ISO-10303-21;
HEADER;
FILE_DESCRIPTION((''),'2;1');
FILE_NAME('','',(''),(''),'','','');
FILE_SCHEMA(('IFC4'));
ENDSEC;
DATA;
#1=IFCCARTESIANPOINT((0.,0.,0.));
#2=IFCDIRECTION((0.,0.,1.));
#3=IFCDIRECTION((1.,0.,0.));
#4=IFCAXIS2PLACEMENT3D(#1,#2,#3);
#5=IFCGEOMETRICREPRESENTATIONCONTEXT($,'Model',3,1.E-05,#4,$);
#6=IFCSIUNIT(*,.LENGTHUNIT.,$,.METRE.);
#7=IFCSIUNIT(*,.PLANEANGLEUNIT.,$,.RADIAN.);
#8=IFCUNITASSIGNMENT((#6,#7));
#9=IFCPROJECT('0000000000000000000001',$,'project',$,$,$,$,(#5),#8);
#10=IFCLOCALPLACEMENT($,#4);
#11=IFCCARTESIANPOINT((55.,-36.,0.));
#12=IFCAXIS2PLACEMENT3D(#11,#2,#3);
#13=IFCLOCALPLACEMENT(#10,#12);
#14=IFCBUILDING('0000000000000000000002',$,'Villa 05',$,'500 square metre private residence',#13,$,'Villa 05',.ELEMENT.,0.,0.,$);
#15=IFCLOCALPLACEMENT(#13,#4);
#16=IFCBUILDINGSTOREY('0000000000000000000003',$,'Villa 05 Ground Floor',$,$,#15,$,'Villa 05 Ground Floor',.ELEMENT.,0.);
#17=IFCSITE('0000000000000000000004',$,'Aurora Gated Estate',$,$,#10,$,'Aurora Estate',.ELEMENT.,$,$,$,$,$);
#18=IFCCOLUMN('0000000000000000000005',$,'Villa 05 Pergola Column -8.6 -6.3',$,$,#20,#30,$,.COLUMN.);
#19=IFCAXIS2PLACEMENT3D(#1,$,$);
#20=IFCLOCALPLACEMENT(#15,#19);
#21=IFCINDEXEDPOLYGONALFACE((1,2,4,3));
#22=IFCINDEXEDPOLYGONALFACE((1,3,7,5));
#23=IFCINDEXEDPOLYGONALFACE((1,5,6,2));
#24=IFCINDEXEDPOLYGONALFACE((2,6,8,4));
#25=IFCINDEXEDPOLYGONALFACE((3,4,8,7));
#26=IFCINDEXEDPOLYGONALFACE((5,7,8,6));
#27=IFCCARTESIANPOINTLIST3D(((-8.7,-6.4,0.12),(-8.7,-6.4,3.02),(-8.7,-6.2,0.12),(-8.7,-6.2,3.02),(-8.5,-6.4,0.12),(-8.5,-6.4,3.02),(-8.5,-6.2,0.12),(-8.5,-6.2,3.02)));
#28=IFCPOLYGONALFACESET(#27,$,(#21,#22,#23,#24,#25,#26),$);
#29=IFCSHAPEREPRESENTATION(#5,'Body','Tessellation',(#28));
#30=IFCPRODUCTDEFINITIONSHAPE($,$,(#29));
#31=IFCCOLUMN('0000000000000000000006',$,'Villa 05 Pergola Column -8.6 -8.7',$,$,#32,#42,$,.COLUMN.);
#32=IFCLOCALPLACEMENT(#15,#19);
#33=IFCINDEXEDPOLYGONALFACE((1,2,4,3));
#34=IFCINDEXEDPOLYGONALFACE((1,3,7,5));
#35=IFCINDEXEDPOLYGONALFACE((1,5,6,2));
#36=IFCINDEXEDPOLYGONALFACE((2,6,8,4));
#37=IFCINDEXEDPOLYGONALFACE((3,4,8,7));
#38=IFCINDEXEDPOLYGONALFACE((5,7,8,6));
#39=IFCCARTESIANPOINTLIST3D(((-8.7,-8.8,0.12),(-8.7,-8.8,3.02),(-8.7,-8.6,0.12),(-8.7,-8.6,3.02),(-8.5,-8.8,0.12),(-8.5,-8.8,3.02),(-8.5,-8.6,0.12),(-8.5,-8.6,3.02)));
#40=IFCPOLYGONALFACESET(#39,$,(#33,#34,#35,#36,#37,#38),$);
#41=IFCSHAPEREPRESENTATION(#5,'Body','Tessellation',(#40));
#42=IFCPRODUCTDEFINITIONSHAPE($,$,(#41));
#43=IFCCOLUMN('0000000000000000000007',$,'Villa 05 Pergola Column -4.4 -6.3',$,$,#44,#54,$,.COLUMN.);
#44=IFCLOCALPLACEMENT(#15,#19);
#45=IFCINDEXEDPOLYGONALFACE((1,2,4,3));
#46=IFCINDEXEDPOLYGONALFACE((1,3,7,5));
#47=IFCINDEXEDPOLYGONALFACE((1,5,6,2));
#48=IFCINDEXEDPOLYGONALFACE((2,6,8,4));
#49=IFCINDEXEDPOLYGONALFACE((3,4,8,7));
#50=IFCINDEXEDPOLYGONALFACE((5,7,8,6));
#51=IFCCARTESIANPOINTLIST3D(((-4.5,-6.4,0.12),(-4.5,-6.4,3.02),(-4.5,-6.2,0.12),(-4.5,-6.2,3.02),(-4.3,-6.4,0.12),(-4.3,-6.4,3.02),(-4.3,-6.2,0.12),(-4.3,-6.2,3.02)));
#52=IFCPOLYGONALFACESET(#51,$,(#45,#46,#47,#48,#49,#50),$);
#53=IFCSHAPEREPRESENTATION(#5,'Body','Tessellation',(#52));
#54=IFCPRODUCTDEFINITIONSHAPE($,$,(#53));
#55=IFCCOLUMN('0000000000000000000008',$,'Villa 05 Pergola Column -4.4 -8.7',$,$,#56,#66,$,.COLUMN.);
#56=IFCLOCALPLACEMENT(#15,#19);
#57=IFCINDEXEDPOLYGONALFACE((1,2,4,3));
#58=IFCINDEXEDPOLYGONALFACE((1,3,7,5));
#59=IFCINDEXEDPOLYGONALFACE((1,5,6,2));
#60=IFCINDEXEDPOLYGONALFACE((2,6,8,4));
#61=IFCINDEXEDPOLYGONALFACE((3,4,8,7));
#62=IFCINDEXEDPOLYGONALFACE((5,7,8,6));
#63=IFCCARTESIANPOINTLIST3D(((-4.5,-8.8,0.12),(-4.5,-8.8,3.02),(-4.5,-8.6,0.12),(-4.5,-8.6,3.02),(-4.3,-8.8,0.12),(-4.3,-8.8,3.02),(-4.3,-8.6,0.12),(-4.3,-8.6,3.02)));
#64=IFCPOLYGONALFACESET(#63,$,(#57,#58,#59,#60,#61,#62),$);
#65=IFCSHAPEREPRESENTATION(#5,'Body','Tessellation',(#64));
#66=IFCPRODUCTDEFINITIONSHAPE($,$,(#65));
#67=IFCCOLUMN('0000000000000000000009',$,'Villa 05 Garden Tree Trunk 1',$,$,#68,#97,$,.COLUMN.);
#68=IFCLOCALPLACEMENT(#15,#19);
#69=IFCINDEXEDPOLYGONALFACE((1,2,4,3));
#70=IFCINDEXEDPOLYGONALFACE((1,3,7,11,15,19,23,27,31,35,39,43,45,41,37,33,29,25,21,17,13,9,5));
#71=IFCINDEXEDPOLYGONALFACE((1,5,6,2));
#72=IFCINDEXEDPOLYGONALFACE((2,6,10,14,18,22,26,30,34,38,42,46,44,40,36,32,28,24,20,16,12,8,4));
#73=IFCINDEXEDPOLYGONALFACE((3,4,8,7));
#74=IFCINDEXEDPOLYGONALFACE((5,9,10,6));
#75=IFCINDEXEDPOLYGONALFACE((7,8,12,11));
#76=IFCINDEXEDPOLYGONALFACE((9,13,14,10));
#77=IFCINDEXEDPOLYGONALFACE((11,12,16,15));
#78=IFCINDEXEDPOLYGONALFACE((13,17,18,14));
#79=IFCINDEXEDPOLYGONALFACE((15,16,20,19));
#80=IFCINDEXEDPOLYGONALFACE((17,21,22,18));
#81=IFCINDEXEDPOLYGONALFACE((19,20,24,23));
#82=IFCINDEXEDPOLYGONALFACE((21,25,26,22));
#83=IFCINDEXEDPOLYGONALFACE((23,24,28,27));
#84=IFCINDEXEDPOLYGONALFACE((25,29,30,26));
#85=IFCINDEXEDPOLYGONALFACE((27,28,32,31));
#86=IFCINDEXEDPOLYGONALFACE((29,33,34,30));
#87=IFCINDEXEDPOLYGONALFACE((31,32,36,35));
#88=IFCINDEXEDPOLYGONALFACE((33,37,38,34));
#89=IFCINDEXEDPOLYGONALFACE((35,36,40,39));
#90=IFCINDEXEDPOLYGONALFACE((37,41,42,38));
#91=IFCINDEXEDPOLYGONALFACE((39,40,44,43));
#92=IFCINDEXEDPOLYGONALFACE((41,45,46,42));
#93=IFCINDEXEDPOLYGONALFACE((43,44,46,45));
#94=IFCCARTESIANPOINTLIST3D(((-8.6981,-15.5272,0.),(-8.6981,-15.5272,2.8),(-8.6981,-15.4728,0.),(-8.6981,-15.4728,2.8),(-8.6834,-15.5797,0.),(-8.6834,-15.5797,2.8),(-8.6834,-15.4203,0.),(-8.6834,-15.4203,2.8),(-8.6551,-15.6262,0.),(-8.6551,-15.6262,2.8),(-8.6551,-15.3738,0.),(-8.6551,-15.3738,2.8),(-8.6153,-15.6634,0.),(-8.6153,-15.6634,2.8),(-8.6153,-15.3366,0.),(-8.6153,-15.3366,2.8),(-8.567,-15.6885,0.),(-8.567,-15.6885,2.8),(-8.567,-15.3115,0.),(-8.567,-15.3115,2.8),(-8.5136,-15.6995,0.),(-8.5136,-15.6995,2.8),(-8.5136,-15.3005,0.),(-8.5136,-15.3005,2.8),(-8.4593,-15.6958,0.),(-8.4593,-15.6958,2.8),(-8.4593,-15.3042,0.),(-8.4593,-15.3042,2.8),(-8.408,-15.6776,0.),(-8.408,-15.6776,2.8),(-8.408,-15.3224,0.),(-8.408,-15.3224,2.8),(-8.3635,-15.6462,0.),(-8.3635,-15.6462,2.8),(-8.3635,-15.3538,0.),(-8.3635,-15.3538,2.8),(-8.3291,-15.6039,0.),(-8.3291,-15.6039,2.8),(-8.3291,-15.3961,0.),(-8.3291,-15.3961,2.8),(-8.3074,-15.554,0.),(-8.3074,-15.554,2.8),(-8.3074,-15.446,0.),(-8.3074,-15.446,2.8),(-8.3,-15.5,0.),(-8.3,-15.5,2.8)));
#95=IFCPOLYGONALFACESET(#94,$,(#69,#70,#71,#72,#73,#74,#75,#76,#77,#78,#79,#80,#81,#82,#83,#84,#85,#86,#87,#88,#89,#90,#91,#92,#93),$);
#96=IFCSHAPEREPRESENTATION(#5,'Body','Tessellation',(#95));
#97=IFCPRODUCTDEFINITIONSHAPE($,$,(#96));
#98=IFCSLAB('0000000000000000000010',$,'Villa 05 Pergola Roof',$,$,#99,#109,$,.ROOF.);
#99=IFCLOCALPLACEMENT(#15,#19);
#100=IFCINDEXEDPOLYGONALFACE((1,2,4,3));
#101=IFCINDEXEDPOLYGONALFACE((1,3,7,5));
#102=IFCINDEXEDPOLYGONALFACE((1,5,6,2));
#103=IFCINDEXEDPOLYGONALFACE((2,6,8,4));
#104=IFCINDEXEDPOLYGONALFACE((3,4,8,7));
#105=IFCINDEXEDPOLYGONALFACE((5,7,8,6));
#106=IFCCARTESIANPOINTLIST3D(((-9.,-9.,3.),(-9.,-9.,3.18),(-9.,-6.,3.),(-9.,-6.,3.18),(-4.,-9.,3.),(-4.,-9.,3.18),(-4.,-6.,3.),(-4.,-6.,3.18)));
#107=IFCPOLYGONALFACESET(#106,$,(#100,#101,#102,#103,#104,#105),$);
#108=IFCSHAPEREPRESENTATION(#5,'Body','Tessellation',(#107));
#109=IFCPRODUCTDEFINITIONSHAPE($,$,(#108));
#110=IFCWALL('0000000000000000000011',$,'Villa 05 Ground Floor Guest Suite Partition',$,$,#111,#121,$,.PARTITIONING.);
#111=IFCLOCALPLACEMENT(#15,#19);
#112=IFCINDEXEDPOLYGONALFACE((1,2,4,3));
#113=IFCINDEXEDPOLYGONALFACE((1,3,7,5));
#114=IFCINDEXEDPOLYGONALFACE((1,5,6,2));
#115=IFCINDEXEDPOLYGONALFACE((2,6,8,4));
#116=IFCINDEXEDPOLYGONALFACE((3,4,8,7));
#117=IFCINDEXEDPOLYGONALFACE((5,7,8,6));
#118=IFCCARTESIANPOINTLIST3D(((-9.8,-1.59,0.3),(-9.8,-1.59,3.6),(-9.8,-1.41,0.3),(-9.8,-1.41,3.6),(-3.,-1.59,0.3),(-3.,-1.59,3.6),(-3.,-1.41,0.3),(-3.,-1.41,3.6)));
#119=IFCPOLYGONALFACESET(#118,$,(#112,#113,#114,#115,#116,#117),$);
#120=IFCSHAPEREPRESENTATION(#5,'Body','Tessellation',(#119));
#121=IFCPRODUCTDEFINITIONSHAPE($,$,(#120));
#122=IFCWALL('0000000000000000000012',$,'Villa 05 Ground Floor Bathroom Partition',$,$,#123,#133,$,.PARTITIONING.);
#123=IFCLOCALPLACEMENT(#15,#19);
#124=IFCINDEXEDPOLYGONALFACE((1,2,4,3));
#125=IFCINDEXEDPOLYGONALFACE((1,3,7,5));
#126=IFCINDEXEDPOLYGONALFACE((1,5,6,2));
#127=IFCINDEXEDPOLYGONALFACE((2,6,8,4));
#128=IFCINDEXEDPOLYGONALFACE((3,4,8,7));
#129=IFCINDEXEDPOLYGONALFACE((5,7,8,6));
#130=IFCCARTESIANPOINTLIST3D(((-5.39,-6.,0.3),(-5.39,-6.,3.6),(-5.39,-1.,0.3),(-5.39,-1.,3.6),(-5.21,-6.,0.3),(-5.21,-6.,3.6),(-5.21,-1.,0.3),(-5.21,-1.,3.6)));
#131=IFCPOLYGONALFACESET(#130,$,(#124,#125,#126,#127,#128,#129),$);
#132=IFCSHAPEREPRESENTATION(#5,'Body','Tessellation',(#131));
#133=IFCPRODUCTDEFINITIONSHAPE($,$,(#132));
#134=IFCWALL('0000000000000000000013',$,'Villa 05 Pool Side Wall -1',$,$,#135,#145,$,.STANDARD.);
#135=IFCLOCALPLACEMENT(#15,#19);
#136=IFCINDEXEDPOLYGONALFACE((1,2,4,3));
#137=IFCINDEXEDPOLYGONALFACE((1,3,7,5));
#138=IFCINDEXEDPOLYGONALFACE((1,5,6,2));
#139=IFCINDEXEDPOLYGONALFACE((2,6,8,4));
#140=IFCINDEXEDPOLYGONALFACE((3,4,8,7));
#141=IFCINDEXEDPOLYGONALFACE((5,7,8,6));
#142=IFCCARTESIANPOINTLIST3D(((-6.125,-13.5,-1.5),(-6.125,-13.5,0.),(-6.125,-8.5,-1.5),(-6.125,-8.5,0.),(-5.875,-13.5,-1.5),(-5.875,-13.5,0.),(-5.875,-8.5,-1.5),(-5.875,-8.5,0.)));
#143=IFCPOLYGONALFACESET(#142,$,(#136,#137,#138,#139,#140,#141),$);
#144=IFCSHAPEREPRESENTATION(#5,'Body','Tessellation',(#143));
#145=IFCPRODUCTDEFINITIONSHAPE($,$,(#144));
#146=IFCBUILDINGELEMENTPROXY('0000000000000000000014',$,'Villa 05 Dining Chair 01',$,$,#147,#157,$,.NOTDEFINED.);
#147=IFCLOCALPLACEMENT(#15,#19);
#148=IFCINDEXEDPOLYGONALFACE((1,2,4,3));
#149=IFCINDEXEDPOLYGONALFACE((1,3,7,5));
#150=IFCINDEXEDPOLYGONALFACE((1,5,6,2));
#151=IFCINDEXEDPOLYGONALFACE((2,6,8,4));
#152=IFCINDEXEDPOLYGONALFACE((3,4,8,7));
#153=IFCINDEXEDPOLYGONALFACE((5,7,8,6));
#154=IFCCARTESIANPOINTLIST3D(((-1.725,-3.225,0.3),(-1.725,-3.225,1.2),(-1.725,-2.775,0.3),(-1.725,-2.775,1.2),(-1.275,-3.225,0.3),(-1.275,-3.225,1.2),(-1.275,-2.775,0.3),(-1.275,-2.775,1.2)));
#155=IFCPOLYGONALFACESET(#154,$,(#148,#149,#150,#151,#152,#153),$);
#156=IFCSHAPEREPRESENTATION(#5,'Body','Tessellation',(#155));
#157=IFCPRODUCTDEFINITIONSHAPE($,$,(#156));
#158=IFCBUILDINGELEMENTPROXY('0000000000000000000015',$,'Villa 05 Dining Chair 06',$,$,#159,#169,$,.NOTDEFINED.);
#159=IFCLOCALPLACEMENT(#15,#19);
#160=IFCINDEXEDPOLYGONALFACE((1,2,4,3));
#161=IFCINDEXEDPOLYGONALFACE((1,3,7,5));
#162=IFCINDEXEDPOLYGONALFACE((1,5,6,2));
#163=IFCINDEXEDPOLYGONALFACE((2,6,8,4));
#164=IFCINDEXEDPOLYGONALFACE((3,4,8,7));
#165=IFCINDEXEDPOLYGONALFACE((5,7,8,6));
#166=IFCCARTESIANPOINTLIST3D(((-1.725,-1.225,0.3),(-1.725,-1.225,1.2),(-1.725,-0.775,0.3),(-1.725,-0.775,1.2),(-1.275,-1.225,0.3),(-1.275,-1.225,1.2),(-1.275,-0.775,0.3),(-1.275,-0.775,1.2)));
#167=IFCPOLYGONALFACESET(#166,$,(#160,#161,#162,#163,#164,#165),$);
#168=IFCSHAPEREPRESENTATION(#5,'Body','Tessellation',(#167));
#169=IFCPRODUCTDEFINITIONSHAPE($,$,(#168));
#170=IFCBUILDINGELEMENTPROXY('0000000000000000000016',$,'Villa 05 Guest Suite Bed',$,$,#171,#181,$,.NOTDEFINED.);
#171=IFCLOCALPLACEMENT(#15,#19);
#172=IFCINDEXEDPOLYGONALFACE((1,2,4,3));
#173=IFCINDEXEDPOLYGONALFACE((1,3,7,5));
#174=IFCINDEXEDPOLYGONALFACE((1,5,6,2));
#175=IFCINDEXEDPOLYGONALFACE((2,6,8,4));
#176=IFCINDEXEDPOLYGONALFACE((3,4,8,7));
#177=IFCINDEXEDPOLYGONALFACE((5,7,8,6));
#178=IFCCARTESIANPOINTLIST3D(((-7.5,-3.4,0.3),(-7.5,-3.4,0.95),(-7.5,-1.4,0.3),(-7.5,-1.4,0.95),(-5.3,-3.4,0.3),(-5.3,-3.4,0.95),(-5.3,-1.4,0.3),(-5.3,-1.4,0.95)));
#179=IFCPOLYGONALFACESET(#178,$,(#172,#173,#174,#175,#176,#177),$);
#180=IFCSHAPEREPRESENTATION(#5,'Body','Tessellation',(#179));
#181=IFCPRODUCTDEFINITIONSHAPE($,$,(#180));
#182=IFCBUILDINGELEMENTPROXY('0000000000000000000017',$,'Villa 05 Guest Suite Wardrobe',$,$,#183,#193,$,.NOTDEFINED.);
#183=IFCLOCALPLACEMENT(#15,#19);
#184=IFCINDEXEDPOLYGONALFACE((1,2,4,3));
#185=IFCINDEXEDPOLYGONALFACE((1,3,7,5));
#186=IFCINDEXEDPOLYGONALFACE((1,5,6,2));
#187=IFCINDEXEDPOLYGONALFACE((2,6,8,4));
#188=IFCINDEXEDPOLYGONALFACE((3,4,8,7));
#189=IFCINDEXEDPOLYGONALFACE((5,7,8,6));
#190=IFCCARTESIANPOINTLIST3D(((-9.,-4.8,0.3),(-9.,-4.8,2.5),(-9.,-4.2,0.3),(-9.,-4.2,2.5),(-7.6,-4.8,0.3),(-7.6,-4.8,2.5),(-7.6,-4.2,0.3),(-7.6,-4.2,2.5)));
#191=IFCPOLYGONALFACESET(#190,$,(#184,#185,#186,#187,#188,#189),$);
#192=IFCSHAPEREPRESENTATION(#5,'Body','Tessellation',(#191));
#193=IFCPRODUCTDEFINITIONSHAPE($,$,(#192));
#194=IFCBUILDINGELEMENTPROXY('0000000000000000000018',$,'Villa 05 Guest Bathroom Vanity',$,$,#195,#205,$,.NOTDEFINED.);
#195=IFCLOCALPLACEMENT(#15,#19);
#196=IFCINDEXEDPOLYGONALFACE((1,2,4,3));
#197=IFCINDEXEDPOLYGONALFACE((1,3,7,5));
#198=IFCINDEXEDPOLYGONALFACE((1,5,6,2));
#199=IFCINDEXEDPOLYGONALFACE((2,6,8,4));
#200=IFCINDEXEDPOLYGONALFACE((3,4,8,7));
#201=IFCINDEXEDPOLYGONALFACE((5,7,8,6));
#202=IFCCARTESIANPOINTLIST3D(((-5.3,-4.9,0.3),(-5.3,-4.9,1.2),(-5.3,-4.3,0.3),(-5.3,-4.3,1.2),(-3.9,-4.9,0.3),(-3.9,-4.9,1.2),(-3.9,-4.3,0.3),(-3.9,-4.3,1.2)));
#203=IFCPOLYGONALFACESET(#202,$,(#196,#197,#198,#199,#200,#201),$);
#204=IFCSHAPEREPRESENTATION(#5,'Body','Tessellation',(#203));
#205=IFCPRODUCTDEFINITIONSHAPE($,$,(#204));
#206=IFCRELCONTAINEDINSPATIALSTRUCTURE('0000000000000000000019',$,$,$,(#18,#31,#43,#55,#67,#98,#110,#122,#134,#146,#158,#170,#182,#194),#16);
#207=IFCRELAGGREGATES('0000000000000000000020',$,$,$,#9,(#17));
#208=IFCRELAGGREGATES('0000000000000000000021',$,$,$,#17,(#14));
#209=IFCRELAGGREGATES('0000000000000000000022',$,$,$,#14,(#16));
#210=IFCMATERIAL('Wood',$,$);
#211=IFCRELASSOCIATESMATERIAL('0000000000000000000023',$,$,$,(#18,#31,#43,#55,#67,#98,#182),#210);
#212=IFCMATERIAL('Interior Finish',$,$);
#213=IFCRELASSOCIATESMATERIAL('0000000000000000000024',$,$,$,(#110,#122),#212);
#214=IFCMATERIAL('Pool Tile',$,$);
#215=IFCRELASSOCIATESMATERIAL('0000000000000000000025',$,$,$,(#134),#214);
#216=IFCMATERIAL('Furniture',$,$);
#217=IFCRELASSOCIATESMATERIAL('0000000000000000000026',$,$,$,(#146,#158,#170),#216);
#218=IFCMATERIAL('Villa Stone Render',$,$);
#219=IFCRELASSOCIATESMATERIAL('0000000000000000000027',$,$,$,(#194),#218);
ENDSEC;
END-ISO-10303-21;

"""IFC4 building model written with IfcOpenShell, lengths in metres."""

from ifc_helpers import new_model, si_unit, frame, origin_with_axes, origin_2d_with_axis, place, context, project, spatial, rectangle, circle, extrude, material, element, save


model = new_model("IFC4")

# Units and contexts
model_context = context("Model", 3, precision=1e-05, world=origin_with_axes())
ifc_project = project(units=[si_unit("LENGTHUNIT", "METRE"), si_unit("PLANEANGLEUNIT", "RADIAN")], contexts=[model_context])

# Site, building, storey
site_placement = place(None, origin_with_axes())
site = spatial("IfcSite", under=ifc_project, at=site_placement, Name="Aurora Gated Estate", LongName="Aurora Estate", CompositionType="ELEMENT")
building_placement = place(site_placement, frame((55.0, -36.0, 0.0), z_axis=(0.0, 0.0, 1.0), x_axis=(1.0, 0.0, 0.0)))
building = spatial("IfcBuilding", under=site, at=building_placement, Name="Villa 05", ObjectType="500 square metre private residence", LongName="Villa 05", CompositionType="ELEMENT", ElevationOfRefHeight=0.0, ElevationOfTerrain=0.0)
storey_placement = place(building_placement, origin_with_axes())
storey = spatial("IfcBuildingStorey", under=building, at=storey_placement, Name="Villa 05 Ground Floor", LongName="Villa 05 Ground Floor", CompositionType="ELEMENT", Elevation=0.0)

# Columns
ifc_material_1 = material(Name="Wood")
for number, where, z_axis, x_axis, name in (
    (1, (-8.6, -6.3, 0.12), (0.0, 0.0, 1.0), (1.0, 0.0, 0.0), "Villa 05 Pergola Column -8.6 -6.3"),
    (2, (-8.6, -8.7, 0.12), (0.0, 0.0, 1.0), (1.0, 0.0, 0.0), "Villa 05 Pergola Column -8.6 -8.7"),
    (3, (-4.4, -6.3, 0.12), (0.0, 0.0, 1.0), (1.0, 0.0, 0.0), "Villa 05 Pergola Column -4.4 -6.3"),
    (4, (-4.4, -8.7, 0.12), (0.0, 0.0, 1.0), (1.0, 0.0, 0.0), "Villa 05 Pergola Column -4.4 -8.7"),
):
    element("IfcColumn", number, at=place(storey_placement, frame(where, z_axis=z_axis, x_axis=x_axis)), inside=storey, material=ifc_material_1, Name=name, PredefinedType="COLUMN", context=model_context, shape_type="SweptSolid", body=[
        extrude(rectangle(XDim=0.2, YDim=0.2, at=origin_2d_with_axis()), origin_with_axes(), (0.0, 0.0, 1.0), 2.9),
    ])
column_placement = place(storey_placement, frame((-8.5, -15.5, 0.0), z_axis=(0.0, 0.0, 1.0), x_axis=(1.0, 0.0, 0.0)))
element("IfcColumn", 5, at=column_placement, inside=storey, material=ifc_material_1, Name="Villa 05 Garden Tree Trunk 1", PredefinedType="COLUMN", context=model_context, shape_type="SweptSolid", body=[
    extrude(circle(Radius=0.2, at=origin_2d_with_axis()), origin_with_axes(), (0.0, 0.0, 1.0), 2.8),
])

# Slab
slab_placement = place(storey_placement, frame((-6.5, -7.5, 3.0), z_axis=(0.0, 0.0, 1.0), x_axis=(1.0, 0.0, 0.0)))
element("IfcSlab", 6, at=slab_placement, inside=storey, material=ifc_material_1, Name="Villa 05 Pergola Roof", PredefinedType="ROOF", context=model_context, shape_type="SweptSolid", body=[
    extrude(rectangle(XDim=5.0, YDim=3.0, at=origin_2d_with_axis()), origin_with_axes(), (0.0, 0.0, 1.0), 0.18),
])

# Walls
ifc_material_2 = material(Name="Interior Finish")
wall_1_placement = place(storey_placement, frame((-6.4, -1.5, 0.3), z_axis=(0.0, 0.0, 1.0), x_axis=(1.0, 0.0, 0.0)))
element("IfcWall", 7, at=wall_1_placement, inside=storey, material=ifc_material_2, Name="Villa 05 Ground Floor Guest Suite Partition", PredefinedType="PARTITIONING", context=model_context, shape_type="SweptSolid", body=[
    extrude(rectangle(XDim=6.8, YDim=0.18, at=origin_2d_with_axis()), origin_with_axes(), (0.0, 0.0, 1.0), 3.3),
])
wall_2_placement = place(storey_placement, frame((-5.3, -3.5, 0.3), z_axis=(0.0, 0.0, 1.0), x_axis=(1.0, 0.0, 0.0)))
element("IfcWall", 8, at=wall_2_placement, inside=storey, material=ifc_material_2, Name="Villa 05 Ground Floor Bathroom Partition", PredefinedType="PARTITIONING", context=model_context, shape_type="SweptSolid", body=[
    extrude(rectangle(XDim=0.18, YDim=5.0, at=origin_2d_with_axis()), origin_with_axes(), (0.0, 0.0, 1.0), 3.3),
])
ifc_material_3 = material(Name="Pool Tile")
wall_3_placement = place(storey_placement, frame((-6.0, -11.0, -1.5), z_axis=(0.0, 0.0, 1.0), x_axis=(1.0, 0.0, 0.0)))
element("IfcWall", 9, at=wall_3_placement, inside=storey, material=ifc_material_3, Name="Villa 05 Pool Side Wall -1", PredefinedType="STANDARD", context=model_context, shape_type="SweptSolid", body=[
    extrude(rectangle(XDim=0.25, YDim=5.0, at=origin_2d_with_axis()), origin_with_axes(), (0.0, 0.0, 1.0), 1.5),
])

# Building element proxies
ifc_material_4 = material(Name="Furniture")
for number, where, z_axis, x_axis, name in (
    (10, (-1.5, -3.0, 0.3), (0.0, 0.0, 1.0), (1.0, 0.0, 0.0), "Villa 05 Dining Chair 01"),
    (11, (-1.5, -1.0, 0.3), (0.0, 0.0, 1.0), (1.0, 0.0, 0.0), "Villa 05 Dining Chair 06"),
):
    element("IfcBuildingElementProxy", number, at=place(storey_placement, frame(where, z_axis=z_axis, x_axis=x_axis)), inside=storey, material=ifc_material_4, Name=name, PredefinedType="NOTDEFINED", context=model_context, shape_type="SweptSolid", body=[
        extrude(rectangle(XDim=0.45, YDim=0.45, at=origin_2d_with_axis()), origin_with_axes(), (0.0, 0.0, 1.0), 0.9),
    ])
proxy_1_placement = place(storey_placement, frame((-6.4, -2.4, 0.3), z_axis=(0.0, 0.0, 1.0), x_axis=(1.0, 0.0, 0.0)))
element("IfcBuildingElementProxy", 12, at=proxy_1_placement, inside=storey, material=ifc_material_4, Name="Villa 05 Guest Suite Bed", PredefinedType="NOTDEFINED", context=model_context, shape_type="SweptSolid", body=[
    extrude(rectangle(XDim=2.2, YDim=2.0, at=origin_2d_with_axis()), origin_with_axes(), (0.0, 0.0, 1.0), 0.65),
])
proxy_2_placement = place(storey_placement, frame((-8.3, -4.5, 0.3), z_axis=(0.0, 0.0, 1.0), x_axis=(1.0, 0.0, 0.0)))
element("IfcBuildingElementProxy", 13, at=proxy_2_placement, inside=storey, material=ifc_material_1, Name="Villa 05 Guest Suite Wardrobe", PredefinedType="NOTDEFINED", context=model_context, shape_type="SweptSolid", body=[
    extrude(rectangle(XDim=1.4, YDim=0.6, at=origin_2d_with_axis()), origin_with_axes(), (0.0, 0.0, 1.0), 2.2),
])
ifc_material_5 = material(Name="Villa Stone Render")
proxy_3_placement = place(storey_placement, frame((-4.6, -4.6, 0.3), z_axis=(0.0, 0.0, 1.0), x_axis=(1.0, 0.0, 0.0)))
element("IfcBuildingElementProxy", 14, at=proxy_3_placement, inside=storey, material=ifc_material_5, Name="Villa 05 Guest Bathroom Vanity", PredefinedType="NOTDEFINED", context=model_context, shape_type="SweptSolid", body=[
    extrude(rectangle(XDim=1.4, YDim=0.6, at=origin_2d_with_axis()), origin_with_axes(), (0.0, 0.0, 1.0), 0.9),
])

save(model, "model.ifc")
